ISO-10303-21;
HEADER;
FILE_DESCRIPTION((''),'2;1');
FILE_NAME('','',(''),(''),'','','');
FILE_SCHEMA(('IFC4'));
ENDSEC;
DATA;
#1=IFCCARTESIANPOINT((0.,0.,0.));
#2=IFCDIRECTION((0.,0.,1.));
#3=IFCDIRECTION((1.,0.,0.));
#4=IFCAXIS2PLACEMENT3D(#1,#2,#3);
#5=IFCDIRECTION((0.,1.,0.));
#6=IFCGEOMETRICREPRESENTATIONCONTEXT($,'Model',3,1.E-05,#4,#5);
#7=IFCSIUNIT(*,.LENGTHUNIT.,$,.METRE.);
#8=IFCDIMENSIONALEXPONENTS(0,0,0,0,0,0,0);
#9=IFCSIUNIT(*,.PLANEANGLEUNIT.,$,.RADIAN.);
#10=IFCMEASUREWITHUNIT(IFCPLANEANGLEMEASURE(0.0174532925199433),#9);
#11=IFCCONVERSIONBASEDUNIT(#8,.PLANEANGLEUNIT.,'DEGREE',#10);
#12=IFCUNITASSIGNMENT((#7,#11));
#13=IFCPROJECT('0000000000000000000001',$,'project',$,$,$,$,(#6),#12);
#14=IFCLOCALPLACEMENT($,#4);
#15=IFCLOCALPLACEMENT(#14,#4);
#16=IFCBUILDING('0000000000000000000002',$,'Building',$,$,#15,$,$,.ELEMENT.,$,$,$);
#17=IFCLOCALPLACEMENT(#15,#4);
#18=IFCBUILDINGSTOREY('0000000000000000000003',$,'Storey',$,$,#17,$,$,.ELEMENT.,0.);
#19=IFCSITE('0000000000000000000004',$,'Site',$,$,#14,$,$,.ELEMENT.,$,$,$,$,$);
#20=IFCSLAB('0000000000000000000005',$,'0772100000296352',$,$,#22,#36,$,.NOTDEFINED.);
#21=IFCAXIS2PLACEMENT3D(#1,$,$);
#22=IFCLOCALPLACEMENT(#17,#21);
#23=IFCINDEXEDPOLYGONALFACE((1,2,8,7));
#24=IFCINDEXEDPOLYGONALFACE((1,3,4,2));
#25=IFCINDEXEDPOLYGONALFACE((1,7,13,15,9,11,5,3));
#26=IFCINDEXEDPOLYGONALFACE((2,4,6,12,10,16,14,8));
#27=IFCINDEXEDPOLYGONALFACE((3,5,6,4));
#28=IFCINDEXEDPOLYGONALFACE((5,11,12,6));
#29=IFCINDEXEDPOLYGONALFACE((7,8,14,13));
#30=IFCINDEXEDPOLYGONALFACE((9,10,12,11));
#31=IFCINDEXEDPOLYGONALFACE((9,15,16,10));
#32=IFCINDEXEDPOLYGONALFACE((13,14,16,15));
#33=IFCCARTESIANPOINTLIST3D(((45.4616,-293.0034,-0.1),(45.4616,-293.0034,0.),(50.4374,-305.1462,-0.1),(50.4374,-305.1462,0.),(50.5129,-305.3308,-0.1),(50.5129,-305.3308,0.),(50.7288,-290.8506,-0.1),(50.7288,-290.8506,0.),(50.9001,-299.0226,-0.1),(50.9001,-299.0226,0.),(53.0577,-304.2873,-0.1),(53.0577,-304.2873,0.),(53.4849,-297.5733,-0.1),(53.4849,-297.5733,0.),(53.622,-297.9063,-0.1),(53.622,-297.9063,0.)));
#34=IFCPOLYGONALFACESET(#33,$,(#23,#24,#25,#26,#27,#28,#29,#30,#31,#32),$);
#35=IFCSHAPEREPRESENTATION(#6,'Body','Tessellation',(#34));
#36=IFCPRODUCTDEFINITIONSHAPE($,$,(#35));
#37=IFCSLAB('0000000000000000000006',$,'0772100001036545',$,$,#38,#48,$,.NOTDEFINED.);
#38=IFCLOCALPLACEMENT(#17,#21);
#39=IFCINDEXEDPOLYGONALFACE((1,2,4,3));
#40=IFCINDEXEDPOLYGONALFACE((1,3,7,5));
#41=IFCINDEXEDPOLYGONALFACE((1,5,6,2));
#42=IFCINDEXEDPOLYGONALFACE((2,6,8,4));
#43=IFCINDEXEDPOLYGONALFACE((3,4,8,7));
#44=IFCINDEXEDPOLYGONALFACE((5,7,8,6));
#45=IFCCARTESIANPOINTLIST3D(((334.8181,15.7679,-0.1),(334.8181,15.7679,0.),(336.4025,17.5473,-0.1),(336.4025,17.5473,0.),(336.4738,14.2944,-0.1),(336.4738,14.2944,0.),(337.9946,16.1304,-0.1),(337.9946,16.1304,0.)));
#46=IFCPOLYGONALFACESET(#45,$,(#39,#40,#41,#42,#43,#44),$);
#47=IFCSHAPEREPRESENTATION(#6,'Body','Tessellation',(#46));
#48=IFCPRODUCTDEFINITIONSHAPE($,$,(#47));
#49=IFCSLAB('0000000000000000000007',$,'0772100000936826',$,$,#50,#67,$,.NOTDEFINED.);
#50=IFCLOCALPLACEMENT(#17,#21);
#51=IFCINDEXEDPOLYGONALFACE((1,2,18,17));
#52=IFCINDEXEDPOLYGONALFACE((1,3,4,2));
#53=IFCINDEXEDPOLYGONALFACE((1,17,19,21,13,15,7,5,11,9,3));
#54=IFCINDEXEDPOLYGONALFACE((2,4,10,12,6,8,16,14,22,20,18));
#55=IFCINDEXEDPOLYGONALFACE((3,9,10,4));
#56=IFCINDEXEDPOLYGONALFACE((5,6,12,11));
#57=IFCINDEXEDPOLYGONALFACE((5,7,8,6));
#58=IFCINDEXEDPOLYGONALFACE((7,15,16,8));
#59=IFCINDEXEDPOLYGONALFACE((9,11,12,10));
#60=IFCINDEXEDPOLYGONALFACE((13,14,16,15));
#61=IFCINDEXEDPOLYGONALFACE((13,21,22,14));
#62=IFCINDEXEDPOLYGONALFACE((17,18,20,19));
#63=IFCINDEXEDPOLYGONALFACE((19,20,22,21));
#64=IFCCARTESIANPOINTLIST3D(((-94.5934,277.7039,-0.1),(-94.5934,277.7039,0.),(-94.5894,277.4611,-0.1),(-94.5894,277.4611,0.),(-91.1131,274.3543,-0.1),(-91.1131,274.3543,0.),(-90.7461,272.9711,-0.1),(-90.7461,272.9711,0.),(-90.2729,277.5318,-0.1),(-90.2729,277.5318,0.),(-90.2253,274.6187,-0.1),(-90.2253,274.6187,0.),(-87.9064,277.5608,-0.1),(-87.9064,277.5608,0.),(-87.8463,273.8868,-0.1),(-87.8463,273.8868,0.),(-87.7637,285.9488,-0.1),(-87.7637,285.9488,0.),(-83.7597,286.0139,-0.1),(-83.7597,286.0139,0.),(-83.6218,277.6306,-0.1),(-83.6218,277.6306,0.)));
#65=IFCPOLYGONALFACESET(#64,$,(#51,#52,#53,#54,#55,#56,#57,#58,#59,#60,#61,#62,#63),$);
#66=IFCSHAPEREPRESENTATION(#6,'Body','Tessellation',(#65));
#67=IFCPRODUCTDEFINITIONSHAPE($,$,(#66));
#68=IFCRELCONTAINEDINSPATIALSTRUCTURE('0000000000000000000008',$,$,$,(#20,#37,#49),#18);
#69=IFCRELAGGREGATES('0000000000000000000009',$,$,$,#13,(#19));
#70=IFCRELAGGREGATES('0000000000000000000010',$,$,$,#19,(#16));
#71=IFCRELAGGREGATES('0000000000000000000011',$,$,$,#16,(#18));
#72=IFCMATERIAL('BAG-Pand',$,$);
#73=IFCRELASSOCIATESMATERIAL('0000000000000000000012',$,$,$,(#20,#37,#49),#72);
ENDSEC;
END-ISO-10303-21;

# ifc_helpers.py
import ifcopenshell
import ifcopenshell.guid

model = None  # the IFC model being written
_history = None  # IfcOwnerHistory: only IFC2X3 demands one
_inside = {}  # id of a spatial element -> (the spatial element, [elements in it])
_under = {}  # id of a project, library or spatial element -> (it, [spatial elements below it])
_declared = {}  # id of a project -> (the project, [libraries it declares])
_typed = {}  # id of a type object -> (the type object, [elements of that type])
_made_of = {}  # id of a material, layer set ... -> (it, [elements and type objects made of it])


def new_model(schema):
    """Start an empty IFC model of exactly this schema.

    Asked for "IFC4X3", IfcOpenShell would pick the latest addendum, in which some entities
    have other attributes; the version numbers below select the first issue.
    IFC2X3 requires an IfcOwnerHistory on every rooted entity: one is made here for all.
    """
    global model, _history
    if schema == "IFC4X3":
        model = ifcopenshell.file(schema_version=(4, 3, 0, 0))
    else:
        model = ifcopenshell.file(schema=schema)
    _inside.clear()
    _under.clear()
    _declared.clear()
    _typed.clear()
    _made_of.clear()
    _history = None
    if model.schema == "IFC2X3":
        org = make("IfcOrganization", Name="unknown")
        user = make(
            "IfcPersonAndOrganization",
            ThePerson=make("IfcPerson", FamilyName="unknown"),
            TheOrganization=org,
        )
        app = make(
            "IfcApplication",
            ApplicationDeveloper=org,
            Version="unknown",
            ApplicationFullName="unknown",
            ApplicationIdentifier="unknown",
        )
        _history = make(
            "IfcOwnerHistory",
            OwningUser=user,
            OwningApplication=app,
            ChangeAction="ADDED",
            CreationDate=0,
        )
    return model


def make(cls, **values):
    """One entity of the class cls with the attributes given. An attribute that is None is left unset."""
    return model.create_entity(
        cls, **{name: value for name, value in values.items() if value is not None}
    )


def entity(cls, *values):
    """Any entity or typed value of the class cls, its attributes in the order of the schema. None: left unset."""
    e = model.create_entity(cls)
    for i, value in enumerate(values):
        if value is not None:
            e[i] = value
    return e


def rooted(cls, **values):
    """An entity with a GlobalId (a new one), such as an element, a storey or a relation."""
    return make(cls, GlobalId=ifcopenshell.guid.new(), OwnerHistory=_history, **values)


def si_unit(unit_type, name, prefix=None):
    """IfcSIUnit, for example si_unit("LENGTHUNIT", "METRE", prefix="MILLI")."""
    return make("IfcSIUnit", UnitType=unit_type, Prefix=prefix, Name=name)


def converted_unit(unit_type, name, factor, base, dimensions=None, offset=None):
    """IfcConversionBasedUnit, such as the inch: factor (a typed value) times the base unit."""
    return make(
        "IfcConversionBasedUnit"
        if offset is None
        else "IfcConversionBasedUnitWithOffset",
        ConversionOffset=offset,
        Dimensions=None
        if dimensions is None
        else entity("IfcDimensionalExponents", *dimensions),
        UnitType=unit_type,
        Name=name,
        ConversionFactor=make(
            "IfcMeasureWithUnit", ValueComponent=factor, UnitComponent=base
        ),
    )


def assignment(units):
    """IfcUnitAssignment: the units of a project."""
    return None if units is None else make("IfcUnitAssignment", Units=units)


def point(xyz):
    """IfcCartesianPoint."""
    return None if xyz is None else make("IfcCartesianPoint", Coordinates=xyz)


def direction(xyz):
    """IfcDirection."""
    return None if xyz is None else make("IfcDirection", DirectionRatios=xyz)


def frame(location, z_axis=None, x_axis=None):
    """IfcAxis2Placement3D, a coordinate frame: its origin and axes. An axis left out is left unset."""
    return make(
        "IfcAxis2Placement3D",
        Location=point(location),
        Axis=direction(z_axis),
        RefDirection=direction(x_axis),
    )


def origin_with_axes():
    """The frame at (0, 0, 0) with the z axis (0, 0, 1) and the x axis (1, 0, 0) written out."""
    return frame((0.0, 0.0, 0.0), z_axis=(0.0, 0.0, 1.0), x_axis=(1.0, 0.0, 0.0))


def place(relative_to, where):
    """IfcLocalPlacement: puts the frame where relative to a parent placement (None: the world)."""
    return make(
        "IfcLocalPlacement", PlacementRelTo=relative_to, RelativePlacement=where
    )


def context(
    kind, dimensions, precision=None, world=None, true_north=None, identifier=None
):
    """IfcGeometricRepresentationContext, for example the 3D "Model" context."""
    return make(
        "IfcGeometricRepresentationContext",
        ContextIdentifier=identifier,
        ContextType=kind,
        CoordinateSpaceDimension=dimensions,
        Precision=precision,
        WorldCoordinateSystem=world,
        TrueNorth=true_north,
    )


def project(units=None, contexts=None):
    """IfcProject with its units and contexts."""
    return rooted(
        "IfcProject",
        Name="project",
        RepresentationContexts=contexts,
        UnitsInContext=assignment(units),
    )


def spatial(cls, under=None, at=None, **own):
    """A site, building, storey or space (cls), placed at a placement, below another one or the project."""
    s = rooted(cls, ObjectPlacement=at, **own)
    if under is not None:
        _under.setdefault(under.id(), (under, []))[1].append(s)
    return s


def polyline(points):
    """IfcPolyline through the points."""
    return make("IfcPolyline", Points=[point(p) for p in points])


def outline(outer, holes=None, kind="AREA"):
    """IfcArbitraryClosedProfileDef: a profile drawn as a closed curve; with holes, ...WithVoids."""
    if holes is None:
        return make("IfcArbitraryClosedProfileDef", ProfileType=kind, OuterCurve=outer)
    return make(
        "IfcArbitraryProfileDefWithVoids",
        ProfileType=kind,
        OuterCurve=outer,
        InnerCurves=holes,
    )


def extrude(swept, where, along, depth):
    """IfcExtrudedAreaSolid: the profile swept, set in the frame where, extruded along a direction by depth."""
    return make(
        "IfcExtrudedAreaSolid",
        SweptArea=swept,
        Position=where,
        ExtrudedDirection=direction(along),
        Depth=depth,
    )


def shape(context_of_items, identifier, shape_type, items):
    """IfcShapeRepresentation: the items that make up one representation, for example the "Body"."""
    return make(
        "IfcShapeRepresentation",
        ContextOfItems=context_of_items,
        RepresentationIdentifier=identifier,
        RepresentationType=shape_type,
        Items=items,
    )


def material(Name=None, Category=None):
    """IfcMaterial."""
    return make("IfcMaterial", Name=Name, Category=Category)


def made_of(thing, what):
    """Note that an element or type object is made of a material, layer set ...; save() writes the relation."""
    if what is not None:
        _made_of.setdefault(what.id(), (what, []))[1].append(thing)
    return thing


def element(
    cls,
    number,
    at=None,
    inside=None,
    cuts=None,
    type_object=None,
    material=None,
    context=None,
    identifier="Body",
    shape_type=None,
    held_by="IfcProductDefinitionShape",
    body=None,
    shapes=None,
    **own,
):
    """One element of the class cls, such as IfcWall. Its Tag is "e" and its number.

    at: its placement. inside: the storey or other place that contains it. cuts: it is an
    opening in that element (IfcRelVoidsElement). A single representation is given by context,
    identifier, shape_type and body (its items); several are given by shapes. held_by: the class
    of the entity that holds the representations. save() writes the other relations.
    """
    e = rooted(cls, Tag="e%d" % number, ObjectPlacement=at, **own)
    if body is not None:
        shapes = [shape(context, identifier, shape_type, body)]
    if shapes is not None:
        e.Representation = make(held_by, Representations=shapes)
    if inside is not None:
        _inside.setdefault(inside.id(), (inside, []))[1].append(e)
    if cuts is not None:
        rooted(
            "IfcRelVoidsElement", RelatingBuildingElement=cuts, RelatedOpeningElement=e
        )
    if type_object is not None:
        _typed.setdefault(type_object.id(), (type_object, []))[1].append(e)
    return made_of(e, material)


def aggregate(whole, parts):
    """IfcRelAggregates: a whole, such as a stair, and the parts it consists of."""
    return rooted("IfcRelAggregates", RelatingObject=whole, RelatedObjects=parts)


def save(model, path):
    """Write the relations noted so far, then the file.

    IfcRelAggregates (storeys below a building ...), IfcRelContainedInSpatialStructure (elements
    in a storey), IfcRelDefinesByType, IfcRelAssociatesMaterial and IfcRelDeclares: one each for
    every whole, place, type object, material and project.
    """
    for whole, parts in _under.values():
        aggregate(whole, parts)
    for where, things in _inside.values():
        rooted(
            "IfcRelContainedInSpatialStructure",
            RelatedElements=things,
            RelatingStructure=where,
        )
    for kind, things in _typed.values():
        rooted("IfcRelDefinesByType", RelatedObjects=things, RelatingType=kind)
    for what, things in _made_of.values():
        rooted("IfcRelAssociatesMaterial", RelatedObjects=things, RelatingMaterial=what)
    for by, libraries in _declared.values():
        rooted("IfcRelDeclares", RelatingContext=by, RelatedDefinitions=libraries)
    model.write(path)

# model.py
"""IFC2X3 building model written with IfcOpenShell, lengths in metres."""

from ifc_helpers import new_model, entity, si_unit, converted_unit, direction, frame, origin_with_axes, place, context, project, spatial, polyline, outline, extrude, material, element, save


model = new_model("IFC2X3")

# Units and contexts
model_context = context("Model", 3, precision=1e-05, world=origin_with_axes(), true_north=direction((0.0, 1.0, 0.0)))
ifc_project = project(units=[si_unit("LENGTHUNIT", "METRE"), converted_unit("PLANEANGLEUNIT", "DEGREE", entity("IfcPlaneAngleMeasure", 0.0174532925199433), si_unit("PLANEANGLEUNIT", "RADIAN"), dimensions=[0, 0, 0, 0, 0, 0, 0])], contexts=[model_context])

# Site, building, storey
site_placement = place(None, origin_with_axes())
site = spatial("IfcSite", under=ifc_project, at=site_placement, Name="Site", CompositionType="ELEMENT")
building_placement = place(site_placement, origin_with_axes())
building = spatial("IfcBuilding", under=site, at=building_placement, Name="Building", CompositionType="ELEMENT")
storey_placement = place(building_placement, origin_with_axes())
storey = spatial("IfcBuildingStorey", under=building, at=storey_placement, Name="Storey", CompositionType="ELEMENT", Elevation=0.0)

# Slabs
ifc_material = material(Name="BAG-Pand")
slab_1_placement = place(storey_placement, frame((0.0, 0.0, -0.1), z_axis=(0.0, 0.0, 1.0), x_axis=(1.0, 0.0, 0.0)))
element("IfcSlab", 1, at=slab_1_placement, inside=storey, material=ifc_material, Name="0772100000296352", PredefinedType="NOTDEFINED", context=model_context, shape_type="SweptSolid", body=[
    extrude(outline(polyline([(50.5129, -305.3308), (50.4374, -305.1462), (45.4616, -293.0034), (50.7288, -290.8506), (53.4849, -297.5733), (53.622, -297.9063), (50.9001, -299.0226), (53.0577, -304.2873), (50.5129, -305.3308)])), origin_with_axes(), (0.0, 0.0, 1.0), 0.1),
])
slab_2_placement = place(storey_placement, frame((0.0, 0.0, -0.1), z_axis=(0.0, 0.0, 1.0), x_axis=(1.0, 0.0, 0.0)))
element("IfcSlab", 2, at=slab_2_placement, inside=storey, material=ifc_material, Name="0772100001036545", PredefinedType="NOTDEFINED", context=model_context, shape_type="SweptSolid", body=[
    extrude(outline(polyline([(334.8181, 15.7679), (336.4025, 17.5473), (337.9946, 16.1304), (336.4738, 14.2944), (334.8181, 15.7679)])), origin_with_axes(), (0.0, 0.0, 1.0), 0.1),
])
slab_3_placement = place(storey_placement, frame((0.0, 0.0, -0.1), z_axis=(0.0, 0.0, 1.0), x_axis=(1.0, 0.0, 0.0)))
element("IfcSlab", 3, at=slab_3_placement, inside=storey, material=ifc_material, Name="0772100000936826", PredefinedType="NOTDEFINED", context=model_context, shape_type="SweptSolid", body=[
    extrude(outline(polyline([(-83.7597, 286.0139), (-83.6218, 277.6306), (-87.9064, 277.5608), (-87.8463, 273.8868), (-90.7461, 272.9711), (-91.1131, 274.3543), (-90.2253, 274.6187), (-90.2729, 277.5318), (-94.5894, 277.4611), (-94.5934, 277.7039), (-87.7637, 285.9488), (-83.7597, 286.0139)])), origin_with_axes(), (0.0, 0.0, 1.0), 0.1),
])

save(model, "model.ifc")
